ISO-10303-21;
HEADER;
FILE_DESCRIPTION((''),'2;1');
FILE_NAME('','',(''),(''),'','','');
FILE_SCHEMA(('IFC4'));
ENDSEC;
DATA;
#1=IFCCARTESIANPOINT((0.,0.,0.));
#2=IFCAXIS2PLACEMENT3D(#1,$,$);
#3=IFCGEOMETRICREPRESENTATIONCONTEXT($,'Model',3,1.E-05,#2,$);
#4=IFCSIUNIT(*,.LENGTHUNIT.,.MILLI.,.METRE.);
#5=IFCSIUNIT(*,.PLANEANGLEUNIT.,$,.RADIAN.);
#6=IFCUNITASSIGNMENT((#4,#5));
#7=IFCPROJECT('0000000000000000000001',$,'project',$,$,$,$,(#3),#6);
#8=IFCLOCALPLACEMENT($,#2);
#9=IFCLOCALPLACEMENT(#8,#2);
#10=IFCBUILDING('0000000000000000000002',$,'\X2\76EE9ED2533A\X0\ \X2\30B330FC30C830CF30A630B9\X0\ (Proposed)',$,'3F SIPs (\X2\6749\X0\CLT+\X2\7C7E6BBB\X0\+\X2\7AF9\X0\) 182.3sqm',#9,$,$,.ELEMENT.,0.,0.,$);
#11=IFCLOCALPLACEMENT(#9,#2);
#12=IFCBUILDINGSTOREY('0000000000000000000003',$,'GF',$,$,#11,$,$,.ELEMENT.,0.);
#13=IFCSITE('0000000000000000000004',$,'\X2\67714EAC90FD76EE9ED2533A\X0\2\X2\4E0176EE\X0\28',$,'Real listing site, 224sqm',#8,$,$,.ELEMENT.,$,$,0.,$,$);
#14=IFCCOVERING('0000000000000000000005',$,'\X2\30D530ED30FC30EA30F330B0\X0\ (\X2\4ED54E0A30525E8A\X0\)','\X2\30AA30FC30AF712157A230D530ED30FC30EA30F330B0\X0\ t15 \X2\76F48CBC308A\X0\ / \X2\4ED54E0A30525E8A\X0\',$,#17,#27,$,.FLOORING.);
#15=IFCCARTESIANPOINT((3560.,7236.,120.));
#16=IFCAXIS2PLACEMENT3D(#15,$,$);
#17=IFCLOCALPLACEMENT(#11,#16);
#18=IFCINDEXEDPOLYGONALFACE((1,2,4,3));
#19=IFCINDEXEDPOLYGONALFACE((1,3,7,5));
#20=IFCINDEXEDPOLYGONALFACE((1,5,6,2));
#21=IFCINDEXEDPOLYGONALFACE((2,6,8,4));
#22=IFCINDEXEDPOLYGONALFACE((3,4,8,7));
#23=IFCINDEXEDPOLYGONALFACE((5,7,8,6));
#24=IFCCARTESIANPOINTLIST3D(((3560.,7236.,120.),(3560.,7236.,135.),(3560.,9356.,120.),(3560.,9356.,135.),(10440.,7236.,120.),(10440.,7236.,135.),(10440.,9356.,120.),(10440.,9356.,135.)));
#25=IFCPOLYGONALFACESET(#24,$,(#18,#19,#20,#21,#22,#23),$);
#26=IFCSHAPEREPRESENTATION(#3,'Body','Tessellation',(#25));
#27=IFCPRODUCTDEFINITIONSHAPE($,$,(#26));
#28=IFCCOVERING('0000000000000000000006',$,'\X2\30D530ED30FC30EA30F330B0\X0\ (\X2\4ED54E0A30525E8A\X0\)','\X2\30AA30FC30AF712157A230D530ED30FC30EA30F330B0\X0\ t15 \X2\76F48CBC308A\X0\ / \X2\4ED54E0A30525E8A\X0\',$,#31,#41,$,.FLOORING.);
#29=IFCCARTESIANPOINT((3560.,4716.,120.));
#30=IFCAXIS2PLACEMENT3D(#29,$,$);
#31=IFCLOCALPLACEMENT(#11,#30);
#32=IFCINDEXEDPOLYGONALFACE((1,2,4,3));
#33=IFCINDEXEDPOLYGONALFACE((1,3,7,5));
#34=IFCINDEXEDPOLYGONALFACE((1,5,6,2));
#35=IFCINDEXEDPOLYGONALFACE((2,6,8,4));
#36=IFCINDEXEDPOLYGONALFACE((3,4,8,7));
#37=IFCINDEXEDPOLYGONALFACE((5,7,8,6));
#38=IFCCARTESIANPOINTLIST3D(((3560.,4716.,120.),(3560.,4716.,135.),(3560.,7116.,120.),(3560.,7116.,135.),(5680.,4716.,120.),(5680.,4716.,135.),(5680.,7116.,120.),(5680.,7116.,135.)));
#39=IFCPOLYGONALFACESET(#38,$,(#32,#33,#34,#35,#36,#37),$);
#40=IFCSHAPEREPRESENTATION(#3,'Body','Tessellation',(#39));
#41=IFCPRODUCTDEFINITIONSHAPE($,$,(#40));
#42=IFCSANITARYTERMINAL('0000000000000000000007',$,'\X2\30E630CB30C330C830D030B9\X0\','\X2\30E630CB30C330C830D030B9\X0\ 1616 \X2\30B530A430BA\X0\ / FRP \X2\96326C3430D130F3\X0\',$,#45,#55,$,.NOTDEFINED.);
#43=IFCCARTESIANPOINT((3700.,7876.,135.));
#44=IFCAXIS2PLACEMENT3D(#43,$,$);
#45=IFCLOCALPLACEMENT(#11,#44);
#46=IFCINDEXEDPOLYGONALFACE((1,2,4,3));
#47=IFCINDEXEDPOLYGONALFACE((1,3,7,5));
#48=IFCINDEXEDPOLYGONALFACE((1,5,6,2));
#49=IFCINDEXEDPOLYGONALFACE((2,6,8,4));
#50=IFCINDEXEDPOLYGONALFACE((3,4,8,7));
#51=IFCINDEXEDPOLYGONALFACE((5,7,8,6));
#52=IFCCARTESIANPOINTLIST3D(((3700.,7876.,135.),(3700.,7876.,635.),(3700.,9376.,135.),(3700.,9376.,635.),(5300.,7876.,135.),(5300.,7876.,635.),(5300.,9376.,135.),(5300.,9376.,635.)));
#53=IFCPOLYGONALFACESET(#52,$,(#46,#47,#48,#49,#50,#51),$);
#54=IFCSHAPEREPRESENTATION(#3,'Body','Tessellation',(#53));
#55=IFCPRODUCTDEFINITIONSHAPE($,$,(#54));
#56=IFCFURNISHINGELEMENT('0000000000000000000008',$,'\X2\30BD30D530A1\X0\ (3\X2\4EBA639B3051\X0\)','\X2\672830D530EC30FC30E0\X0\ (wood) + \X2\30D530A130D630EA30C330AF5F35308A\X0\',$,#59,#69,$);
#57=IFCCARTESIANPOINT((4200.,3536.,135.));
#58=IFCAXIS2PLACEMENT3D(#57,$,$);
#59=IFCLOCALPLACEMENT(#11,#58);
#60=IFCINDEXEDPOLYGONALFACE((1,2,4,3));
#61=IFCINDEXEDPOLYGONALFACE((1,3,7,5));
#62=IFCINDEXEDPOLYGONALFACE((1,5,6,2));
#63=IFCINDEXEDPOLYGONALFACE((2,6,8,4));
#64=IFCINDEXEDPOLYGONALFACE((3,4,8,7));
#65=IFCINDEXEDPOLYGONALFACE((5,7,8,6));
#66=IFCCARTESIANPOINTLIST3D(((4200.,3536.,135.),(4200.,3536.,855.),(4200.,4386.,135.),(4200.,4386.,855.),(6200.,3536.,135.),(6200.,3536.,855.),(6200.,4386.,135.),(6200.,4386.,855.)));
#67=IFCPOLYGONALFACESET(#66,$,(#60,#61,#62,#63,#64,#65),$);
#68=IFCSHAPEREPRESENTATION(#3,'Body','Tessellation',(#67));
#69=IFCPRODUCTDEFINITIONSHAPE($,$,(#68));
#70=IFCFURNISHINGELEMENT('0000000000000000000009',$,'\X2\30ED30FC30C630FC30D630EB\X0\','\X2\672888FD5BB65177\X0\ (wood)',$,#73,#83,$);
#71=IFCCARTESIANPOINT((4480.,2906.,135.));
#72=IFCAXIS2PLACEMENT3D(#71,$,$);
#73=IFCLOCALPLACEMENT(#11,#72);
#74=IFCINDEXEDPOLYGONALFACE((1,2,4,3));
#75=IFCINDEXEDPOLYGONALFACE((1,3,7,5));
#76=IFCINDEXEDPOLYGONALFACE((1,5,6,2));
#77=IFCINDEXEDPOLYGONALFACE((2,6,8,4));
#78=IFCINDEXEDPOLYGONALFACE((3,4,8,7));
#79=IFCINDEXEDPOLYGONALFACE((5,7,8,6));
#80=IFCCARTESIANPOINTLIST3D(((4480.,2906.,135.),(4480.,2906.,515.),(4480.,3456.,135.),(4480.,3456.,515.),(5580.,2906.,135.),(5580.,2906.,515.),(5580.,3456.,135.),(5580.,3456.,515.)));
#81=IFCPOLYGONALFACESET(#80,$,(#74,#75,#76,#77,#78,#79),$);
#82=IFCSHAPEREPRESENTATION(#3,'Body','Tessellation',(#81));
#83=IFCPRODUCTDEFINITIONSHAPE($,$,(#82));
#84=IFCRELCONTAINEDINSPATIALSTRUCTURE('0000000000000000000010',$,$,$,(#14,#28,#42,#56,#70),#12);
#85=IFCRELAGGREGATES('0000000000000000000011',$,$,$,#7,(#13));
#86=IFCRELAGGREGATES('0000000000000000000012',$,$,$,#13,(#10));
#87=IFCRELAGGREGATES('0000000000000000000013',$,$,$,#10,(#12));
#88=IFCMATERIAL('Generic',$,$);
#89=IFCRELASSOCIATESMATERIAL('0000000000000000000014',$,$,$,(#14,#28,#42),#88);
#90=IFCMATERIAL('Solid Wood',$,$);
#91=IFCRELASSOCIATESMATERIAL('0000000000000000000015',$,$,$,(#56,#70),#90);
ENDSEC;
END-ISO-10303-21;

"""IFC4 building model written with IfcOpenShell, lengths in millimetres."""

from ifc_helpers import new_model, si_unit, frame, frame_2d, origin, place, context, project, spatial, rectangle, extrude, material, element, save


model = new_model("IFC4")

# Units and contexts
model_context = context("Model", 3, precision=1e-05, world=origin())
ifc_project = project(units=[si_unit("LENGTHUNIT", "METRE", prefix="MILLI"), si_unit("PLANEANGLEUNIT", "RADIAN")], contexts=[model_context])

# Site, building, storey
site_placement = place(None, origin())
site = spatial("IfcSite", under=ifc_project, at=site_placement, Name="東京都目黒区2丁目28", ObjectType="Real listing site, 224sqm", CompositionType="ELEMENT", RefElevation=0.0)
building_placement = place(site_placement, origin())
building = spatial("IfcBuilding", under=site, at=building_placement, Name="目黒区 コートハウス (Proposed)", ObjectType="3F SIPs (杉CLT+籾殻+竹) 182.3sqm", CompositionType="ELEMENT", ElevationOfRefHeight=0.0, ElevationOfTerrain=0.0)
storey_placement = place(building_placement, origin())
storey = spatial("IfcBuildingStorey", under=building, at=storey_placement, Name="GF", CompositionType="ELEMENT", Elevation=0.0)

# Shared definitions
ifc_material_1 = material(Name="Solid Wood")

# Coverings
ifc_material_2 = material(Name="Generic")
covering_1_placement = place(storey_placement, frame((3560.0, 7236.0, 120.0)))
element("IfcCovering", 1, at=covering_1_placement, inside=storey, material=ifc_material_2, Name="フローリング (仕上げ床)", Description="オーク無垢フローリング t15 直貼り / 仕上げ床", PredefinedType="FLOORING", context=model_context, shape_type="SweptSolid", body=[
    extrude(rectangle(XDim=6880.0, YDim=2120.0, at=frame_2d((3440.0, 1060.0))), frame((3560.0, 7236.0, 120.0)), (0.0, 0.0, 1.0), 15.0),
])
covering_2_placement = place(storey_placement, frame((3560.0, 4716.0, 120.0)))
element("IfcCovering", 2, at=covering_2_placement, inside=storey, material=ifc_material_2, Name="フローリング (仕上げ床)", Description="オーク無垢フローリング t15 直貼り / 仕上げ床", PredefinedType="FLOORING", context=model_context, shape_type="SweptSolid", body=[
    extrude(rectangle(XDim=2120.0, YDim=2400.0, at=frame_2d((1060.0, 1200.0))), frame((3560.0, 4716.0, 120.0)), (0.0, 0.0, 1.0), 15.0),
])

# Sanitary terminal
sanitary_terminal_placement = place(storey_placement, frame((3700.0, 7876.0, 135.0)))
element("IfcSanitaryTerminal", 3, at=sanitary_terminal_placement, inside=storey, material=ifc_material_2, Name="ユニットバス", Description="ユニットバス 1616 サイズ / FRP 防水パン", PredefinedType="NOTDEFINED", context=model_context, shape_type="SweptSolid", body=[
    extrude(rectangle(XDim=1600.0, YDim=1500.0, at=frame_2d((800.0, 750.0))), frame((3700.0, 7876.0, 135.0)), (0.0, 0.0, 1.0), 500.0),
])

# Furnishing elements
furnishing_1_placement = place(storey_placement, frame((4200.0, 3536.0, 135.0)))
element("IfcFurnishingElement", 4, at=furnishing_1_placement, inside=storey, material=ifc_material_1, Name="ソファ (3人掛け)", Description="木フレーム (wood) + ファブリック張り", context=model_context, shape_type="SweptSolid", body=[
    extrude(rectangle(XDim=2000.0, YDim=850.0, at=frame_2d((1000.0, 425.0))), frame((4200.0, 3536.0, 135.0)), (0.0, 0.0, 1.0), 720.0),
])
furnishing_2_placement = place(storey_placement, frame((4480.0, 2906.0, 135.0)))
element("IfcFurnishingElement", 5, at=furnishing_2_placement, inside=storey, material=ifc_material_1, Name="ローテーブル", Description="木製家具 (wood)", context=model_context, shape_type="SweptSolid", body=[
    extrude(rectangle(XDim=1100.0, YDim=550.0, at=frame_2d((550.0, 275.0))), frame((4480.0, 2906.0, 135.0)), (0.0, 0.0, 1.0), 380.0),
])

save(model, "model.ifc")
